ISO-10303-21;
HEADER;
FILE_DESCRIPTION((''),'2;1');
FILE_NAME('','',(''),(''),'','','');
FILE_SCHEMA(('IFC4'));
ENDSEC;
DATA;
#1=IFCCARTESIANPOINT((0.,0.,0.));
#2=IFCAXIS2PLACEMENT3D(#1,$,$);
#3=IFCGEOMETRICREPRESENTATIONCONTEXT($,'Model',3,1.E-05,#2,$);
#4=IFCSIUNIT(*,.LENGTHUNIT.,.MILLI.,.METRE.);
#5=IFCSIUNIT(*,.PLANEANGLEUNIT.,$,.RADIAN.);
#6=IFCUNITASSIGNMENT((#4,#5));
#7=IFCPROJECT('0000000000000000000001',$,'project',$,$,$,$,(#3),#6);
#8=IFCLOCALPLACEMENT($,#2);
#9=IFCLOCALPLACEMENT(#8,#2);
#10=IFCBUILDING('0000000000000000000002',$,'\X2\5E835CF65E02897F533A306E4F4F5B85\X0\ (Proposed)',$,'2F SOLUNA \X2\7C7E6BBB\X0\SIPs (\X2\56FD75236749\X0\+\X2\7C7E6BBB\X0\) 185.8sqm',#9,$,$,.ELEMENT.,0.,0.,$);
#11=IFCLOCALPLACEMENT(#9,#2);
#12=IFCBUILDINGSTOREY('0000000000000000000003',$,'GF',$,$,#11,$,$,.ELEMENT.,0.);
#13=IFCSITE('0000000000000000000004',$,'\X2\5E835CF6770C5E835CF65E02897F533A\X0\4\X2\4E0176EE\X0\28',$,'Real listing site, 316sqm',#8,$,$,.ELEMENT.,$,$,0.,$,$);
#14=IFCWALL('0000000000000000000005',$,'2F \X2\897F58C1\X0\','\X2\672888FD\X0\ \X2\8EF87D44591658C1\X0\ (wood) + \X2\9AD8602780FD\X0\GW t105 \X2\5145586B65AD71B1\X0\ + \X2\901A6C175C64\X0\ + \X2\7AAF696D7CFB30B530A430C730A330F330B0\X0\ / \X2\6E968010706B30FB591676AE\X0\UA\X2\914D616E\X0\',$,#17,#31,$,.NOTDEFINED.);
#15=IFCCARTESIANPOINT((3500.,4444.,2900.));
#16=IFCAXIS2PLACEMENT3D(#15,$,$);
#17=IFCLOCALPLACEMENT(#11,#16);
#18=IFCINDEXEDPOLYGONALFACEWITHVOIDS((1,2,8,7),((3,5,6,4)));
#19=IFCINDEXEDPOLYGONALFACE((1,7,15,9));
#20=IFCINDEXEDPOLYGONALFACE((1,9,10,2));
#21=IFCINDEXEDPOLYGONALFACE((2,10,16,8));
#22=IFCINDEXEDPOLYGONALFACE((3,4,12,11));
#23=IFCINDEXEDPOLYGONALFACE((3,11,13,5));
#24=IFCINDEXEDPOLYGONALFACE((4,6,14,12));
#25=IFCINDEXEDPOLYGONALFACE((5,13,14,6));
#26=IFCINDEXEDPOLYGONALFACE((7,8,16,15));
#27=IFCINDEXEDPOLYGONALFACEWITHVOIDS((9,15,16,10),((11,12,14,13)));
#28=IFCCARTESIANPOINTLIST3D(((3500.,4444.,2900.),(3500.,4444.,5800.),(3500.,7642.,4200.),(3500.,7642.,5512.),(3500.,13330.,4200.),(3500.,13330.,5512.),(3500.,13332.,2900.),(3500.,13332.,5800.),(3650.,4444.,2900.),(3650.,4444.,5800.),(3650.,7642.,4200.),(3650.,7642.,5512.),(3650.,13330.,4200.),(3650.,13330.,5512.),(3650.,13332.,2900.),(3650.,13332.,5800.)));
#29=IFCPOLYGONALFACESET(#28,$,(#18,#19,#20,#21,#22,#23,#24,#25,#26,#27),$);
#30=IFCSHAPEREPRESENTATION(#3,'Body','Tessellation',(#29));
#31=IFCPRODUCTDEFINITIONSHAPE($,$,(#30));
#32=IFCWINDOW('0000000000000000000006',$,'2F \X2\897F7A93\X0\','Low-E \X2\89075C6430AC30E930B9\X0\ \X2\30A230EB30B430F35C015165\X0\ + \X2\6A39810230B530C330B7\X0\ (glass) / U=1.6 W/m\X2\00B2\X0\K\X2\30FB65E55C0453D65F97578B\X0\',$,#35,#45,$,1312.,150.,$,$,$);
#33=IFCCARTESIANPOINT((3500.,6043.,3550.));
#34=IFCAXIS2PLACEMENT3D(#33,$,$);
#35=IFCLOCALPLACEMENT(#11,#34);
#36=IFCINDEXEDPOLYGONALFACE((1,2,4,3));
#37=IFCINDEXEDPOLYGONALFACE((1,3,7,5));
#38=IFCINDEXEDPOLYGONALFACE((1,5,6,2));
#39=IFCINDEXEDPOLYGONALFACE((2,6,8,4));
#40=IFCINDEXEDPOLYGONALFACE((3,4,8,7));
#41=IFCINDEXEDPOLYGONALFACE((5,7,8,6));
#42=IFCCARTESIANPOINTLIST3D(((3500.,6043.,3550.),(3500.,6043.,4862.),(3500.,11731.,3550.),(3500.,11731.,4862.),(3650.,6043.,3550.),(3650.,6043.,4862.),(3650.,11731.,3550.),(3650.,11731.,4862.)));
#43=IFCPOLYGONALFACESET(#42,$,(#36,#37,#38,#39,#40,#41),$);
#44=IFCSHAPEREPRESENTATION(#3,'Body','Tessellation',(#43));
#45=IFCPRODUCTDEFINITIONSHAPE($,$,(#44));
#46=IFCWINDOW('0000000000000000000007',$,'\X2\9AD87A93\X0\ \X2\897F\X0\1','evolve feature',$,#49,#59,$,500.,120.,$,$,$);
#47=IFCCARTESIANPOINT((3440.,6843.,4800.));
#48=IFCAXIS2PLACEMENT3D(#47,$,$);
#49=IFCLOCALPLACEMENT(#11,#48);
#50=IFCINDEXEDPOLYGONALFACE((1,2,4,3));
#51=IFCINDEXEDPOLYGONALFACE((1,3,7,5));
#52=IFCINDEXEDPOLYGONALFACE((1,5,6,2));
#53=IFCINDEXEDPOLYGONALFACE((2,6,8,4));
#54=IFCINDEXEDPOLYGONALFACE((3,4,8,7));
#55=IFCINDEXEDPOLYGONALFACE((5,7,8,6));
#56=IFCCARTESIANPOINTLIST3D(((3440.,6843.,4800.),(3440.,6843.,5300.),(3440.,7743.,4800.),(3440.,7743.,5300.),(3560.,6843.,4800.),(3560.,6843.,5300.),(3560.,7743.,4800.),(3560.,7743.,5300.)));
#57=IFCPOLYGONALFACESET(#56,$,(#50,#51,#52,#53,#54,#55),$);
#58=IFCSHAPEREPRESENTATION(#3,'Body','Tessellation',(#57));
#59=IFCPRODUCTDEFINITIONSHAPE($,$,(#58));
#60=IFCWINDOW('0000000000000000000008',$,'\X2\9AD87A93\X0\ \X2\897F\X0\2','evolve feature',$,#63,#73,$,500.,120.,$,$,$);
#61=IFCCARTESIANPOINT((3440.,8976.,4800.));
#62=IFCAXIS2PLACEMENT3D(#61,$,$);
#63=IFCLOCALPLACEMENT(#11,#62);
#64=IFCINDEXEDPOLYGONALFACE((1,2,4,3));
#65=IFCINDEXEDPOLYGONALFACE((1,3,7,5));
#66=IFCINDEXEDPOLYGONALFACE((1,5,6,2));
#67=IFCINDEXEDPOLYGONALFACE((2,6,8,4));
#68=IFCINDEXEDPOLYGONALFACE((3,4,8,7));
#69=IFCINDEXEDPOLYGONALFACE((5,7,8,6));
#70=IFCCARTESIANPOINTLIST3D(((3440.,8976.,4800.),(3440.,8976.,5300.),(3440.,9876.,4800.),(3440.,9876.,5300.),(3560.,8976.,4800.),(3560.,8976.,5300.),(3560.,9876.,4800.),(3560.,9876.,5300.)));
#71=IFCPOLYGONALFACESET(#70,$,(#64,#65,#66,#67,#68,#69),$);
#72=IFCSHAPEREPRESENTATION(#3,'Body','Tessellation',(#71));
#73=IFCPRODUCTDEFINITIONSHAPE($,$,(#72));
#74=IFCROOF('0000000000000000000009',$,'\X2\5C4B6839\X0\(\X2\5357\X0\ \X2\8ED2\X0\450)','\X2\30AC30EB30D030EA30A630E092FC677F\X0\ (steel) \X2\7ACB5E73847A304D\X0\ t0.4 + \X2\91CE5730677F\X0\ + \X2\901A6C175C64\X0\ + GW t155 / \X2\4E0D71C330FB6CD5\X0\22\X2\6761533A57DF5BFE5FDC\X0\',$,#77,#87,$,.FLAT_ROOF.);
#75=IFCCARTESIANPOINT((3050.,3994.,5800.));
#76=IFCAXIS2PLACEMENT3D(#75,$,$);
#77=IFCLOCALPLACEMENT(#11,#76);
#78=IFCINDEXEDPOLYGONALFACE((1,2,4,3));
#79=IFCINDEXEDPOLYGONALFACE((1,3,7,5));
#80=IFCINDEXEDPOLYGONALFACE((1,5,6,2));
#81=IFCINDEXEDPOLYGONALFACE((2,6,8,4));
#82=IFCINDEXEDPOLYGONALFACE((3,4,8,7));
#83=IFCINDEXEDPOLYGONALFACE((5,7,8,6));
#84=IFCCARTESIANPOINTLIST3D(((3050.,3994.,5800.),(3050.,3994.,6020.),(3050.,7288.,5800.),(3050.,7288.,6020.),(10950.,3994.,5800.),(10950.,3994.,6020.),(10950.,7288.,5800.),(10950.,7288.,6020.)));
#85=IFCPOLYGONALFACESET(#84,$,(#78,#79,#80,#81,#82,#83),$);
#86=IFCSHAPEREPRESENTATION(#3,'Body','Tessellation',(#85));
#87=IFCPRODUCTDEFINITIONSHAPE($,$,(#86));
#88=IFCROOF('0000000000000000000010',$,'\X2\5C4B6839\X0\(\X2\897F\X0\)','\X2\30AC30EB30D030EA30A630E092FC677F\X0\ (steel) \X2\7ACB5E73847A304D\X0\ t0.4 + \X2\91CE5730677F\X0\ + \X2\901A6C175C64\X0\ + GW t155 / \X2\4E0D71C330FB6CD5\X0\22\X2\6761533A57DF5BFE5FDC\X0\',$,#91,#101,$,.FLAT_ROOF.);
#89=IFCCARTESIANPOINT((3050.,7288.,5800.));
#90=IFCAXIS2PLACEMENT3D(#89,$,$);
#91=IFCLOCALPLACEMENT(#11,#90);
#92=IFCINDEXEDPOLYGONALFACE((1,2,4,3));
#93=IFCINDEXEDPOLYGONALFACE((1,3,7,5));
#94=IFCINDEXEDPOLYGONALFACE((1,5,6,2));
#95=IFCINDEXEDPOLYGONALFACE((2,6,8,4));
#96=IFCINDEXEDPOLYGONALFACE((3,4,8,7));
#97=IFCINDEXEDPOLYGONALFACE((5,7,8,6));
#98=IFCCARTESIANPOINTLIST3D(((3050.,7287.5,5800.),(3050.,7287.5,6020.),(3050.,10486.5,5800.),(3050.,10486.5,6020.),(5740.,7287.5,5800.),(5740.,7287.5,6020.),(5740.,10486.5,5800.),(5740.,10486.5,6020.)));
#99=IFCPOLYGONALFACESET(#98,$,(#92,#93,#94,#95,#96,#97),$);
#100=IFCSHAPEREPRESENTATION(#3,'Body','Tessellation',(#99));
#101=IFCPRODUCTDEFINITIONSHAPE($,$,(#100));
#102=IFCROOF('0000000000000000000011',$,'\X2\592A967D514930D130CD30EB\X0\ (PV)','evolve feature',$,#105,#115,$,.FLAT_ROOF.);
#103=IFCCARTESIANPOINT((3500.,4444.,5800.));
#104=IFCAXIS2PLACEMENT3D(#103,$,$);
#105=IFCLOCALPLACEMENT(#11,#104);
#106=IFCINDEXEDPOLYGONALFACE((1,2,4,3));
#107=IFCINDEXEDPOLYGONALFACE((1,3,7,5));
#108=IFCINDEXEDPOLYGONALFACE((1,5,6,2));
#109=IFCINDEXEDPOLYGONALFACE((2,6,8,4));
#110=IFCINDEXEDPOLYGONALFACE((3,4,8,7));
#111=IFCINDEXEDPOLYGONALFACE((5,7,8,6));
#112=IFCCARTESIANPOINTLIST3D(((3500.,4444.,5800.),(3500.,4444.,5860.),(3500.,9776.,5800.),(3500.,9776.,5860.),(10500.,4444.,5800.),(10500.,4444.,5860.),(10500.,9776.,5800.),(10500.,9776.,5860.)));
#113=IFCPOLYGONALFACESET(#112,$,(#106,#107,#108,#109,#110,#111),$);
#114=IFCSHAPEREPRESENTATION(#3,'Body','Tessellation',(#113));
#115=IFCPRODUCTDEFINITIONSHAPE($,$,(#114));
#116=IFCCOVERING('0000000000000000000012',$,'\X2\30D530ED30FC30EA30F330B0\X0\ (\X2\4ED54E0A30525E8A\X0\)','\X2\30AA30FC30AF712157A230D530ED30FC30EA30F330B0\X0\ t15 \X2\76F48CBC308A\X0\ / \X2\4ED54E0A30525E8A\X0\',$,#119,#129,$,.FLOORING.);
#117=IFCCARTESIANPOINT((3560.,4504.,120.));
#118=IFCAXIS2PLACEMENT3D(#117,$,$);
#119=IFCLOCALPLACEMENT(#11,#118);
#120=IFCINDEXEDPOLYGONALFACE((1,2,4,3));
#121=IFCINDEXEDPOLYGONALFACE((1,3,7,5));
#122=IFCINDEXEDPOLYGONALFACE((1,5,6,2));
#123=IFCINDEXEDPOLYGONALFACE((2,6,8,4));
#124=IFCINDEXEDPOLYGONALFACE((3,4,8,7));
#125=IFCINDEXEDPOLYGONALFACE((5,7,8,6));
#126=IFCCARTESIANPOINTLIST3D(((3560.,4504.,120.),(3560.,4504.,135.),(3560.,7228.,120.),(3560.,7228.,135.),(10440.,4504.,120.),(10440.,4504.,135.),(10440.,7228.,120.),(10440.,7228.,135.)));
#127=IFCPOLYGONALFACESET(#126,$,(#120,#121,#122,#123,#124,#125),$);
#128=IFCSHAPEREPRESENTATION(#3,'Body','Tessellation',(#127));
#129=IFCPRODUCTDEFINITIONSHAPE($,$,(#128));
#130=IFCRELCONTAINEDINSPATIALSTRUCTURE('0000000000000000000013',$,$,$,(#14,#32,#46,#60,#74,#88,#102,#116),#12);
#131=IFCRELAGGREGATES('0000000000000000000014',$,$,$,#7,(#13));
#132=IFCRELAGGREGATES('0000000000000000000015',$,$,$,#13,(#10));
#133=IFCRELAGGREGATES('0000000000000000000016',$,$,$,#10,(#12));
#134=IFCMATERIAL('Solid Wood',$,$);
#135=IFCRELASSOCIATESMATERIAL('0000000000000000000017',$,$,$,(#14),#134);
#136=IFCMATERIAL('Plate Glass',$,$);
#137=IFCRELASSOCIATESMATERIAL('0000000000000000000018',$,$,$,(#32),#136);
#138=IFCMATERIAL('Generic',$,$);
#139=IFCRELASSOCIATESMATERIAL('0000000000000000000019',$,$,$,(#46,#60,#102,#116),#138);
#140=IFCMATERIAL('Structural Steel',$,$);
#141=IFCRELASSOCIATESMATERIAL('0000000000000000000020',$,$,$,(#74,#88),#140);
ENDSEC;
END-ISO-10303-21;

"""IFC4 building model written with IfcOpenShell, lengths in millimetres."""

from ifc_helpers import new_model, si_unit, frame, frame_2d, origin, place, context, project, spatial, rectangle, extrude, material, element, fill, save


model = new_model("IFC4")

# Units and contexts
model_context = context("Model", 3, precision=1e-05, world=origin())
ifc_project = project(units=[si_unit("LENGTHUNIT", "METRE", prefix="MILLI"), si_unit("PLANEANGLEUNIT", "RADIAN")], contexts=[model_context])

# Site, building, storey
site_placement = place(None, origin())
site = spatial("IfcSite", under=ifc_project, at=site_placement, Name="広島県広島市西区4丁目28", ObjectType="Real listing site, 316sqm", CompositionType="ELEMENT", RefElevation=0.0)
building_placement = place(site_placement, origin())
building = spatial("IfcBuilding", under=site, at=building_placement, Name="広島市西区の住宅 (Proposed)", ObjectType="2F SOLUNA 籾殻SIPs (国産杉+籾殻) 185.8sqm", CompositionType="ELEMENT", ElevationOfRefHeight=0.0, ElevationOfTerrain=0.0)
storey_placement = place(building_placement, origin())
storey = spatial("IfcBuildingStorey", under=building, at=storey_placement, Name="GF", CompositionType="ELEMENT", Elevation=0.0)

# Shared definitions
ifc_material_1 = material(Name="Solid Wood")
ifc_material_2 = material(Name="Generic")

# Shared definitions
ifc_material_3 = material(Name="Plate Glass")

# Wall, openings, windows
wall_1_placement = place(storey_placement, frame((3500.0, 4444.0, 2900.0)))
wall_1 = element("IfcWall", 1, at=wall_1_placement, inside=storey, material=ifc_material_1, Name="2F 西壁", Description="木製 軸組外壁 (wood) + 高性能GW t105 充填断熱 + 通気層 + 窯業系サイディング / 準耐火・外皮UA配慮", PredefinedType="NOTDEFINED", context=model_context, shape_type="SweptSolid", body=[
    extrude(rectangle(XDim=150.0, YDim=8888.0, at=frame_2d((75.0, 4444.0))), frame((3500.0, 4444.0, 2900.0)), (0.0, 0.0, 1.0), 2900.0),
])
opening_1_placement = place(storey_placement, frame((3500.0, 6043.0, 3550.0)))
opening_1 = element("IfcOpeningElement", 2, at=opening_1_placement, cuts=wall_1, PredefinedType="NOTDEFINED", context=model_context, shape_type="SweptSolid", body=[
    extrude(rectangle(XDim=150.0, YDim=5688.0, at=frame_2d((75.0, 2844.0))), frame((3500.0, 6043.0, 3550.0)), (0.0, 0.0, 1.0), 1312.0),
])
opening_2_placement = place(storey_placement, frame((3440.0, 6843.0, 4800.0)))
opening_2 = element("IfcOpeningElement", 3, at=opening_2_placement, cuts=wall_1, PredefinedType="NOTDEFINED", context=model_context, shape_type="SweptSolid", body=[
    extrude(rectangle(XDim=120.0, YDim=900.0, at=frame_2d((60.0, 450.0))), frame((3440.0, 6843.0, 4800.0)), (0.0, 0.0, 1.0), 500.0),
])
opening_3_placement = place(storey_placement, frame((3440.0, 8976.0, 4800.0)))
opening_3 = element("IfcOpeningElement", 4, at=opening_3_placement, cuts=wall_1, PredefinedType="NOTDEFINED", context=model_context, shape_type="SweptSolid", body=[
    extrude(rectangle(XDim=120.0, YDim=900.0, at=frame_2d((60.0, 450.0))), frame((3440.0, 8976.0, 4800.0)), (0.0, 0.0, 1.0), 500.0),
])
window_1_placement = place(storey_placement, frame((3500.0, 6043.0, 3550.0)))
window_1 = element("IfcWindow", 5, at=window_1_placement, inside=storey, material=ifc_material_3, Name="2F 西窓", Description="Low-E 複層ガラス アルゴン封入 + 樹脂サッシ (glass) / U=1.6 W/m²K・日射取得型", OverallHeight=1312.0, OverallWidth=150.0, context=model_context, shape_type="SweptSolid", body=[
    extrude(rectangle(XDim=150.0, YDim=5688.0, at=frame_2d((75.0, 2844.0))), frame((3500.0, 6043.0, 3550.0)), (0.0, 0.0, 1.0), 1312.0),
])
fill(opening_1, window_1)
window_2_placement = place(storey_placement, frame((3440.0, 6843.0, 4800.0)))
window_2 = element("IfcWindow", 6, at=window_2_placement, inside=storey, material=ifc_material_2, Name="高窓 西1", Description="evolve feature", OverallHeight=500.0, OverallWidth=120.0, context=model_context, shape_type="SweptSolid", body=[
    extrude(rectangle(XDim=120.0, YDim=900.0, at=frame_2d((60.0, 450.0))), frame((3440.0, 6843.0, 4800.0)), (0.0, 0.0, 1.0), 500.0),
])
fill(opening_2, window_2)
window_3_placement = place(storey_placement, frame((3440.0, 8976.0, 4800.0)))
window_3 = element("IfcWindow", 7, at=window_3_placement, inside=storey, material=ifc_material_2, Name="高窓 西2", Description="evolve feature", OverallHeight=500.0, OverallWidth=120.0, context=model_context, shape_type="SweptSolid", body=[
    extrude(rectangle(XDim=120.0, YDim=900.0, at=frame_2d((60.0, 450.0))), frame((3440.0, 8976.0, 4800.0)), (0.0, 0.0, 1.0), 500.0),
])
fill(opening_3, window_3)

# Roofs
ifc_material_4 = material(Name="Structural Steel")
roof_1_placement = place(storey_placement, frame((3050.0, 3994.0, 5800.0)))
element("IfcRoof", 8, at=roof_1_placement, inside=storey, material=ifc_material_4, Name="屋根(南 軒450)", Description="ガルバリウム鋼板 (steel) 立平葺き t0.4 + 野地板 + 通気層 + GW t155 / 不燃・法22条区域対応", PredefinedType="FLAT_ROOF", context=model_context, shape_type="SweptSolid", body=[
    extrude(rectangle(XDim=7900.0, YDim=3294.0, at=frame_2d((3950.0, 1647.0))), frame((3050.0, 3994.0, 5800.0)), (0.0, 0.0, 1.0), 220.0),
])
roof_2_placement = place(storey_placement, frame((3050.0, 7288.0, 5800.0)))
element("IfcRoof", 9, at=roof_2_placement, inside=storey, material=ifc_material_4, Name="屋根(西)", Description="ガルバリウム鋼板 (steel) 立平葺き t0.4 + 野地板 + 通気層 + GW t155 / 不燃・法22条区域対応", PredefinedType="FLAT_ROOF", context=model_context, shape_type="SweptSolid", body=[
    extrude(rectangle(XDim=2690.0, YDim=3199.0, at=frame_2d((1345.0, 1599.0))), frame((3050.0, 7288.0, 5800.0)), (0.0, 0.0, 1.0), 220.0),
])
roof_3_placement = place(storey_placement, frame((3500.0, 4444.0, 5800.0)))
element("IfcRoof", 10, at=roof_3_placement, inside=storey, material=ifc_material_2, Name="太陽光パネル (PV)", Description="evolve feature", PredefinedType="FLAT_ROOF", context=model_context, shape_type="SweptSolid", body=[
    extrude(rectangle(XDim=7000.0, YDim=5332.0, at=frame_2d((3500.0, 2666.0))), frame((3500.0, 4444.0, 5800.0)), (0.0, 0.0, 1.0), 60.0),
])

# Covering
covering_placement = place(storey_placement, frame((3560.0, 4504.0, 120.0)))
element("IfcCovering", 11, at=covering_placement, inside=storey, material=ifc_material_2, Name="フローリング (仕上げ床)", Description="オーク無垢フローリング t15 直貼り / 仕上げ床", PredefinedType="FLOORING", context=model_context, shape_type="SweptSolid", body=[
    extrude(rectangle(XDim=6880.0, YDim=2724.0, at=frame_2d((3440.0, 1362.0))), frame((3560.0, 4504.0, 120.0)), (0.0, 0.0, 1.0), 15.0),
])

save(model, "model.ifc")
